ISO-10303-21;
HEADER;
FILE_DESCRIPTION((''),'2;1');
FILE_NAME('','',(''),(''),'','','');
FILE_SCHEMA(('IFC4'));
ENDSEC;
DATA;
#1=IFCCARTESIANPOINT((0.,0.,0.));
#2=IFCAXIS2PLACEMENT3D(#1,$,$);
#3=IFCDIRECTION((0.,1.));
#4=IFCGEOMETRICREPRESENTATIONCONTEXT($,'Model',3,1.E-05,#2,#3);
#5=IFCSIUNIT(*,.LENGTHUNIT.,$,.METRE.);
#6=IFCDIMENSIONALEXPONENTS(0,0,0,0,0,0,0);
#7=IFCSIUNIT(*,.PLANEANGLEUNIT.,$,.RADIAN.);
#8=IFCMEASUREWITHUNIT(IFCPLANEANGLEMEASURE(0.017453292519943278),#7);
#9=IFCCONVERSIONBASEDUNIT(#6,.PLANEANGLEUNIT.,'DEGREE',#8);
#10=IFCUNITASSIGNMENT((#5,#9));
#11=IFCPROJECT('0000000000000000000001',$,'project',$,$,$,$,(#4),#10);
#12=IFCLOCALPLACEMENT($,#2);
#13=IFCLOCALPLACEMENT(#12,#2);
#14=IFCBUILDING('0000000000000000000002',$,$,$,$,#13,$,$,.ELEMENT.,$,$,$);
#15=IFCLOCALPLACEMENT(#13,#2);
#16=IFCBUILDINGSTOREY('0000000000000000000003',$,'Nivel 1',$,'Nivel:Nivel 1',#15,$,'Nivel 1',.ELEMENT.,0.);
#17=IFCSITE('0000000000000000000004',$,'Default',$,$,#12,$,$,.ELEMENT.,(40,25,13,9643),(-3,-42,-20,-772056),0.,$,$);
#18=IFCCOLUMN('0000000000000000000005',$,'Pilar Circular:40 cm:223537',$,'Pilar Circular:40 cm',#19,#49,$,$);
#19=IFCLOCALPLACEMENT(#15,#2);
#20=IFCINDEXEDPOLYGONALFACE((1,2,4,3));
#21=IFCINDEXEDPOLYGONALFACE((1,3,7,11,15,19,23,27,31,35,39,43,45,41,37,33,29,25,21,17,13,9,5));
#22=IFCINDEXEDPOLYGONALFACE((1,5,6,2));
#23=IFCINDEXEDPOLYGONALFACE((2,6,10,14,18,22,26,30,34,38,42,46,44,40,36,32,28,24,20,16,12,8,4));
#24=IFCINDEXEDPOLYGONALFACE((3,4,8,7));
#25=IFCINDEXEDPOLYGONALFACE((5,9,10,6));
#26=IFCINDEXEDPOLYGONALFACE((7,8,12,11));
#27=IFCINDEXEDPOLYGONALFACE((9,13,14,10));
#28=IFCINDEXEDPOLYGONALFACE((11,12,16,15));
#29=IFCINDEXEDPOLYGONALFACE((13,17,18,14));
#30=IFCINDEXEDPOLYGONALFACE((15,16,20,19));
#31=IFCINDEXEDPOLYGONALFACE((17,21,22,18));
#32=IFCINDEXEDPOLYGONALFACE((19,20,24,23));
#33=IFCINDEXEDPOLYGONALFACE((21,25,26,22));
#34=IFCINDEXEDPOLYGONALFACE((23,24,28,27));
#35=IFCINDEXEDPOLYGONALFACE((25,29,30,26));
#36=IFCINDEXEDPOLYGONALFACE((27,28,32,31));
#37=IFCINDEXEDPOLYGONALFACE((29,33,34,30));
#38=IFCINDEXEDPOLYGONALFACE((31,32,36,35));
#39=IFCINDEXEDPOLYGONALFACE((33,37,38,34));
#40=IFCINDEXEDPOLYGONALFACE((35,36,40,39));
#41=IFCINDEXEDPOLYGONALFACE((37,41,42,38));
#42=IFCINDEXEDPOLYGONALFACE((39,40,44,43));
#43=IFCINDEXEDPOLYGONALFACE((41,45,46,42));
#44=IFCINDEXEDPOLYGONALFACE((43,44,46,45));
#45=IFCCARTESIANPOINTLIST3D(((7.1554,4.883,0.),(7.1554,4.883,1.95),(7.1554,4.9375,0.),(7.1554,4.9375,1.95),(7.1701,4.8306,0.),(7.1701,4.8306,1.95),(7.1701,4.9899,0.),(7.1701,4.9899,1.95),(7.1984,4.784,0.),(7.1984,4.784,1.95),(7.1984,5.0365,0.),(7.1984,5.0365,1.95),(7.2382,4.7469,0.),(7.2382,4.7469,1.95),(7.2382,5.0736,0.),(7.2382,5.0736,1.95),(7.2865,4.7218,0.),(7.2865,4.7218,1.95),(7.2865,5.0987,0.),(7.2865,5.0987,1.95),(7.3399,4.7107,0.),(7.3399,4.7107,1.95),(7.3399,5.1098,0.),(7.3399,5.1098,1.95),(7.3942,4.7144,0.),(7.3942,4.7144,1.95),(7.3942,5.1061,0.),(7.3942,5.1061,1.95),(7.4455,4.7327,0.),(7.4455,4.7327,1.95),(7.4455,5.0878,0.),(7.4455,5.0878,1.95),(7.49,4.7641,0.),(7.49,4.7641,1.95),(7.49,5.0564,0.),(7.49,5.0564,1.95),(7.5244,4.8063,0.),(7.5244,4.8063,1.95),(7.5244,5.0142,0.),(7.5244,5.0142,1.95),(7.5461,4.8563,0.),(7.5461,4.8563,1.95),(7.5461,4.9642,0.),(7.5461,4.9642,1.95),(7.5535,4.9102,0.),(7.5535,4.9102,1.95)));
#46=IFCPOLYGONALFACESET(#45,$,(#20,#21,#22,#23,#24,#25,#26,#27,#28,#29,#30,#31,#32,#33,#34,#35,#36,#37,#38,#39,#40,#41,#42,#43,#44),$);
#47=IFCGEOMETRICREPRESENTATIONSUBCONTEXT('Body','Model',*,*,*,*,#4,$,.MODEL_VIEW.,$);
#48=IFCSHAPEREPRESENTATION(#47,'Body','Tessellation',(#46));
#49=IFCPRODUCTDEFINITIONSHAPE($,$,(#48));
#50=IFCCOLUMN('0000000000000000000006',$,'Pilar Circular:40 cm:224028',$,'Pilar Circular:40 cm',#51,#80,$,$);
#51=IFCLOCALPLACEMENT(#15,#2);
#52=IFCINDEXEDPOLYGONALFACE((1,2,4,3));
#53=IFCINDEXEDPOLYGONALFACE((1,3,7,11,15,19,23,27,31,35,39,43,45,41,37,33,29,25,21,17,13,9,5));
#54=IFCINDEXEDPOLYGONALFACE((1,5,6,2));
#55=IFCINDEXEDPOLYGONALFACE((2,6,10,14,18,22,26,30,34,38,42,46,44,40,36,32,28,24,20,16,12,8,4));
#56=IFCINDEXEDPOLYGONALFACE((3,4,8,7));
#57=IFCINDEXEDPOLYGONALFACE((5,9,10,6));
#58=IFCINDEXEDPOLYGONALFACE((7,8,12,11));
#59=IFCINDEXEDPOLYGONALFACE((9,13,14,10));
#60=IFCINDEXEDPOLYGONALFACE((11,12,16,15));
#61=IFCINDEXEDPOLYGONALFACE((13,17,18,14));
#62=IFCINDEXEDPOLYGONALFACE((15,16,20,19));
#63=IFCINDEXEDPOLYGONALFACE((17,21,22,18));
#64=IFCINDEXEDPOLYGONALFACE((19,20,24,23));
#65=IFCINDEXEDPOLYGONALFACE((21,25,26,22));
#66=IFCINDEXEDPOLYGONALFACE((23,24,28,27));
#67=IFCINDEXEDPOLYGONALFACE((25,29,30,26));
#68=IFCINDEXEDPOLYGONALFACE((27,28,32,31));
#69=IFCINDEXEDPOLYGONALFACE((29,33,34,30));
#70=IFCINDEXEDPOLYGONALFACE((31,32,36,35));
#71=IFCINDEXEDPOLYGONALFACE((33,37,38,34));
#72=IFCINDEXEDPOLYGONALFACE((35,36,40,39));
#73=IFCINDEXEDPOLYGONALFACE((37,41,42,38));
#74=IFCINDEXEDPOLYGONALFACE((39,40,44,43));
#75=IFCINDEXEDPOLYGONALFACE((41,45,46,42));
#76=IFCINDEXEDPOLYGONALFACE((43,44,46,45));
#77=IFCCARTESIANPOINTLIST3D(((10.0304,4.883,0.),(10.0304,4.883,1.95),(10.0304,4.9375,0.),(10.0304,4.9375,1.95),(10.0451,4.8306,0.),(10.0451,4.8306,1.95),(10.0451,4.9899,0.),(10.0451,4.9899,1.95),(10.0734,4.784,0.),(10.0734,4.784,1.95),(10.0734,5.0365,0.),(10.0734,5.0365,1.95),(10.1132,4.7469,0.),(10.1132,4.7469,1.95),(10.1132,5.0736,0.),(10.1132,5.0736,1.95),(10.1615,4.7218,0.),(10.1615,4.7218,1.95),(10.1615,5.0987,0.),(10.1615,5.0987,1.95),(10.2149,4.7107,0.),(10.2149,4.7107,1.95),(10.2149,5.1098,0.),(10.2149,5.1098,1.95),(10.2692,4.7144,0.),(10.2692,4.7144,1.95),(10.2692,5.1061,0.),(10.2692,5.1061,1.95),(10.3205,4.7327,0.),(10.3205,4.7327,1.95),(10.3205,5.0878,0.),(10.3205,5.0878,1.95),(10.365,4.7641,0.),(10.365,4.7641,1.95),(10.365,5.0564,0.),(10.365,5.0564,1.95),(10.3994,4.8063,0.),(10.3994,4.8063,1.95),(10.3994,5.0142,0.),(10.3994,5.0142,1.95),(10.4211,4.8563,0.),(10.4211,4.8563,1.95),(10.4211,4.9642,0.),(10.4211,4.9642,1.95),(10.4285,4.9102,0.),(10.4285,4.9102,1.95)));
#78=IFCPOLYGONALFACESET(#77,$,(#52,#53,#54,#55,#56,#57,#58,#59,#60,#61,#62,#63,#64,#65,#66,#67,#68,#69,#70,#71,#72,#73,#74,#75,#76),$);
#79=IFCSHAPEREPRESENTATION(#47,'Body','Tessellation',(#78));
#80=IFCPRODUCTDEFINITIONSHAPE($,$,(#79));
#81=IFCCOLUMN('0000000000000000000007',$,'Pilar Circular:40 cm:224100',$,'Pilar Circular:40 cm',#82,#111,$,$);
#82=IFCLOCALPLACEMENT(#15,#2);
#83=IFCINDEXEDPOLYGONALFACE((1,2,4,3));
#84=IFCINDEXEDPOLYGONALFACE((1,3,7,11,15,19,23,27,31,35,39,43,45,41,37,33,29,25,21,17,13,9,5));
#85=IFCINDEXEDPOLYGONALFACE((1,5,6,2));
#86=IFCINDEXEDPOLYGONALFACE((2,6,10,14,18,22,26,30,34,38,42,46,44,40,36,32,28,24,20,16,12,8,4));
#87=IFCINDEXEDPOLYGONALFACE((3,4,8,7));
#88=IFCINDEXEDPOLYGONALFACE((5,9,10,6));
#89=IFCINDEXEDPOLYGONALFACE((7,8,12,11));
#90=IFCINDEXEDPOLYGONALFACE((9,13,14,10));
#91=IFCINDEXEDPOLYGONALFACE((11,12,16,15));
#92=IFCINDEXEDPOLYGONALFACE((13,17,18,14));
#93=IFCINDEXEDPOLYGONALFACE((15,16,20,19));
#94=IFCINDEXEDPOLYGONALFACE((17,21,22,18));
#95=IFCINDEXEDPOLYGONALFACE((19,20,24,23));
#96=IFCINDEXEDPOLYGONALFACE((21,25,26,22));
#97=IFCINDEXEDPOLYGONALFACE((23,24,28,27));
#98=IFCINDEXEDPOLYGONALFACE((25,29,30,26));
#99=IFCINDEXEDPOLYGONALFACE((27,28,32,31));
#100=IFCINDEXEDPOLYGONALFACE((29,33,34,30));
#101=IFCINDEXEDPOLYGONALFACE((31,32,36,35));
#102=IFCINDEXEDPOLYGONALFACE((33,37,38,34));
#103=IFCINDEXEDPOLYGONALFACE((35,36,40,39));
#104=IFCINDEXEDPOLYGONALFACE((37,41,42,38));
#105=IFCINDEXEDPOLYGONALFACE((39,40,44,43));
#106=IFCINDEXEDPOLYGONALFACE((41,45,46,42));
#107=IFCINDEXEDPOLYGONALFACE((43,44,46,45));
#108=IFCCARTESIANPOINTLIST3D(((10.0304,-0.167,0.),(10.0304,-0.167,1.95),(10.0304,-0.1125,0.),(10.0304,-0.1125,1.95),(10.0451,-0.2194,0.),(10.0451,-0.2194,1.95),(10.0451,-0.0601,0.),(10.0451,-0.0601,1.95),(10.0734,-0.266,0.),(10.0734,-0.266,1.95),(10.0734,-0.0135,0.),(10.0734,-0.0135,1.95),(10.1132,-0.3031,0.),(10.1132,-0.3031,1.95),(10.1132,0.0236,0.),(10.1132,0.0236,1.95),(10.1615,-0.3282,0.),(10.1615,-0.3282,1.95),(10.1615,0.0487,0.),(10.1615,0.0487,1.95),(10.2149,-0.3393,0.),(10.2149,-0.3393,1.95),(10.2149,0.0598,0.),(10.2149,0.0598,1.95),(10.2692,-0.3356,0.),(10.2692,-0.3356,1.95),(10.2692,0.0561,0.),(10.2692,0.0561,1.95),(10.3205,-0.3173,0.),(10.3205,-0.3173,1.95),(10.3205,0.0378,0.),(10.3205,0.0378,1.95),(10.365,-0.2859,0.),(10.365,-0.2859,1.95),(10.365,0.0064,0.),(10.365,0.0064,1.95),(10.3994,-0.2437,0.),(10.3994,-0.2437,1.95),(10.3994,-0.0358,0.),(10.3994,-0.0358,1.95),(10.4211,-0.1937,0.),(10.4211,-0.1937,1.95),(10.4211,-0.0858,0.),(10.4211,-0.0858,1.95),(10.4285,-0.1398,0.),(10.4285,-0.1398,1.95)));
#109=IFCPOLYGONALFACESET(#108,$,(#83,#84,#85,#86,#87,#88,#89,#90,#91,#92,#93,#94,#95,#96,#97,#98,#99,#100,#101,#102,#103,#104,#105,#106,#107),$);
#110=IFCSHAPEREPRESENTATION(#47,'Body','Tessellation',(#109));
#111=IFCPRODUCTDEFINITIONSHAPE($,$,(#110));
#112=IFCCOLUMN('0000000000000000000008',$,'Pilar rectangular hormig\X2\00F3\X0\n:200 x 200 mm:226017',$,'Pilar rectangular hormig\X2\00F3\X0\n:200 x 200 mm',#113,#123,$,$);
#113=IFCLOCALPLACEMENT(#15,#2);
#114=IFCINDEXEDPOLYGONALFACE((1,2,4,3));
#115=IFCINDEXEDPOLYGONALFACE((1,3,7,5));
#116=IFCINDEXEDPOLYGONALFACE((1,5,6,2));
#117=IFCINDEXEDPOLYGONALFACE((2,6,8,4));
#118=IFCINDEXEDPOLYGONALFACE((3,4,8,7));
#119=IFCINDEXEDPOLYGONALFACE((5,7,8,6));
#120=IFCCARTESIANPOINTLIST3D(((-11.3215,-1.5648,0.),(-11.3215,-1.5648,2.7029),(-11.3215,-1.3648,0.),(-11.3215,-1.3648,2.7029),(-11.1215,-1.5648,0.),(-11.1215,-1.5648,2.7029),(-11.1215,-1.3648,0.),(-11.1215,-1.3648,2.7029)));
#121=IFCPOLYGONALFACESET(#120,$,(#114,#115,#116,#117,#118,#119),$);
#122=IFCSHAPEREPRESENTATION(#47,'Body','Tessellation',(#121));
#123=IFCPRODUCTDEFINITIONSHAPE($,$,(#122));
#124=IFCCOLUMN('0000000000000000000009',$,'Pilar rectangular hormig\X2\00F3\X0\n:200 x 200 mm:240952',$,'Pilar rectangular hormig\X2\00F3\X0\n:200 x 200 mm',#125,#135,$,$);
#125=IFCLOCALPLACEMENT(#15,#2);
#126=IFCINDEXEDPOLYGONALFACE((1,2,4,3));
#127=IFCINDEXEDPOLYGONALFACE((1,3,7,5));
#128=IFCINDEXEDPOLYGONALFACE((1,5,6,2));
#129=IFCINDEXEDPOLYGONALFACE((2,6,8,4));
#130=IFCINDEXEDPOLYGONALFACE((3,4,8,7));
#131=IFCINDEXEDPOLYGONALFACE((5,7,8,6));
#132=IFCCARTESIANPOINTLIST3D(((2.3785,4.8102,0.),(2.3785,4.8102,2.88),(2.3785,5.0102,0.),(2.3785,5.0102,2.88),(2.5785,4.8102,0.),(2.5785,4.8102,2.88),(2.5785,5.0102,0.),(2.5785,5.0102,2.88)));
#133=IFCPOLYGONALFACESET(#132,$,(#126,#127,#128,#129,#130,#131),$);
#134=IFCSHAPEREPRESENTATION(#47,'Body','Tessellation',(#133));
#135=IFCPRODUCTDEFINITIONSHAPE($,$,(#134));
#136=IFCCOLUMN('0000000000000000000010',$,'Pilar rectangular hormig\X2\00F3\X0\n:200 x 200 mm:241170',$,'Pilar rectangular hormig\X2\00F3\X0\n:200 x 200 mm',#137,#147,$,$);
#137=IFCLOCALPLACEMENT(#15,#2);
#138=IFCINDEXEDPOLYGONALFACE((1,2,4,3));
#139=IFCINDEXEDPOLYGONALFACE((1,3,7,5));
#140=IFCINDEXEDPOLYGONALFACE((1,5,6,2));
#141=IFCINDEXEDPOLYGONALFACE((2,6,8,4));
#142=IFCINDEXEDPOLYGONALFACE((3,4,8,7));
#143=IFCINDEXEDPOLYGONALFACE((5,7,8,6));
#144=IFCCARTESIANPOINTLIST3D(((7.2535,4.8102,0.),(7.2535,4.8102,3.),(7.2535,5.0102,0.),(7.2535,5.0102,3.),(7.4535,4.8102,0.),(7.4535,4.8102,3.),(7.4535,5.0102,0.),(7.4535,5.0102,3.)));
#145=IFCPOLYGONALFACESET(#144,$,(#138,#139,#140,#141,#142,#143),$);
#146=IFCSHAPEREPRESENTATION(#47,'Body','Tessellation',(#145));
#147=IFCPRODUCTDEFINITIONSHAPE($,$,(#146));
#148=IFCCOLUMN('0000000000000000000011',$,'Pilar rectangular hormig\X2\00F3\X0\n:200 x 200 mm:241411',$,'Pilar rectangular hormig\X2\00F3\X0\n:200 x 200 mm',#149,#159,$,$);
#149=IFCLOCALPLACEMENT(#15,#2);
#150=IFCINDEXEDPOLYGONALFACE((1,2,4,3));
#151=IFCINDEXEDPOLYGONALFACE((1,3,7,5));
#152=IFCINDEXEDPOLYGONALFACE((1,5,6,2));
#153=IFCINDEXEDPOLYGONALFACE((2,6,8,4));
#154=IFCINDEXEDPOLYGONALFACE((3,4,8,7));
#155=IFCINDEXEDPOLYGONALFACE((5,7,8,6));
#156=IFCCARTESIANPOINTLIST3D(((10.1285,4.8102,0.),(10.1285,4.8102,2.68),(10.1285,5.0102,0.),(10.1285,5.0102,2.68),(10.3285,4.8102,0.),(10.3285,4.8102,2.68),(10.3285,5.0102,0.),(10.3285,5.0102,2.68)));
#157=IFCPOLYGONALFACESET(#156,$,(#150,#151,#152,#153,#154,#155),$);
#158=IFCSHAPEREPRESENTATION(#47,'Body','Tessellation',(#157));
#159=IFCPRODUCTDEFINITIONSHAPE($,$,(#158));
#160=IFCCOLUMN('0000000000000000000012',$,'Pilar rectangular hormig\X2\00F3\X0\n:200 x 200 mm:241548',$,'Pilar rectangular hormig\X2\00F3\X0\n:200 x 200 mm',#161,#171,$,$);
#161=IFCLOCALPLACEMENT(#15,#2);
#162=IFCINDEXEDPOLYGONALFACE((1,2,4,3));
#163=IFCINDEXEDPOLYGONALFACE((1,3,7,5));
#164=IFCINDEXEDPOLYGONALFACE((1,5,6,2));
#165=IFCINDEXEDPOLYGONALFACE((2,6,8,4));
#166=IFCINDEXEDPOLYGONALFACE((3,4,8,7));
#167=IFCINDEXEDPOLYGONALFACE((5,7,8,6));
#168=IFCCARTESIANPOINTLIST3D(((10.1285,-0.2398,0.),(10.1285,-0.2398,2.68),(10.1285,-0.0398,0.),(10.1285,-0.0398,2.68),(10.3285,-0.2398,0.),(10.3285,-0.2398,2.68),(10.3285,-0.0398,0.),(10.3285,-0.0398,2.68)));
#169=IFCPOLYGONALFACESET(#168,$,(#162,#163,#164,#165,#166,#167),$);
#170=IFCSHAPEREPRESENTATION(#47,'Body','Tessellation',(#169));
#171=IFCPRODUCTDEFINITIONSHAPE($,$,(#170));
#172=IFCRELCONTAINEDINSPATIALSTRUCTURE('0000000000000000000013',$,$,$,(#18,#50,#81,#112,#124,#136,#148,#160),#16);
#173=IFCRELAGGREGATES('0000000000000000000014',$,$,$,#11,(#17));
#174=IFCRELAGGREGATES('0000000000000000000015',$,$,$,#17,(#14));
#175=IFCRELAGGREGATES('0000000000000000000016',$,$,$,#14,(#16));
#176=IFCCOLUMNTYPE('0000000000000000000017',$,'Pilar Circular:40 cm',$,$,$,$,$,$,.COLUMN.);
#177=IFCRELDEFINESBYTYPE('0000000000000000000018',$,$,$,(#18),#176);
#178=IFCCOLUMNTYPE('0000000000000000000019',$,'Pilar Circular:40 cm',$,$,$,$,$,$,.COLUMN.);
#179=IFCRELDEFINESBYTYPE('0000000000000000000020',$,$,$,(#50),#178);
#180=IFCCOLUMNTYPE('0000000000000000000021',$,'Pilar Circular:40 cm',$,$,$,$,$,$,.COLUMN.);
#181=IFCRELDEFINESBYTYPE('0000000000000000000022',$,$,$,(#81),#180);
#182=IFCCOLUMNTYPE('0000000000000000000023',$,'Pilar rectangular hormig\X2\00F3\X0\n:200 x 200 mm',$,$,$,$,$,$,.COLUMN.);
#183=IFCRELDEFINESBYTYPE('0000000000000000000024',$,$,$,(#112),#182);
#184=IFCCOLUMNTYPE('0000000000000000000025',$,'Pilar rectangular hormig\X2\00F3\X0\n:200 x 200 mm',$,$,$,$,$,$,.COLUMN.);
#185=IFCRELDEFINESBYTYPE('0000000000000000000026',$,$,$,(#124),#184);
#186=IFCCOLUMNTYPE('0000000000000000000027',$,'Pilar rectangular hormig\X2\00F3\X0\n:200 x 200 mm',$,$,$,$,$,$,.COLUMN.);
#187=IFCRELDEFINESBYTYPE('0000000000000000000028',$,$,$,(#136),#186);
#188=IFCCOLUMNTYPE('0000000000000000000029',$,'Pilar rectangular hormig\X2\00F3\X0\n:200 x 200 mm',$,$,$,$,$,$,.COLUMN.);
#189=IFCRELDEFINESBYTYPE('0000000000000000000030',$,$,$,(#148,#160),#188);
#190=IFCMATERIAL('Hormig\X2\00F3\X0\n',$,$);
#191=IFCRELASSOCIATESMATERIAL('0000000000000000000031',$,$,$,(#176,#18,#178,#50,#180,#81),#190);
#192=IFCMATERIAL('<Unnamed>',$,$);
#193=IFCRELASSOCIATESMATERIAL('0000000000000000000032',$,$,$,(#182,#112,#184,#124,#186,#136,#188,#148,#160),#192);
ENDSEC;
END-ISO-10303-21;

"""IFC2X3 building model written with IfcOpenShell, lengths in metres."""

from ifc_helpers import new_model, entity, si_unit, converted_unit, direction, frame, frame_2d, origin, origin_2d_with_axis, place, context, subcontext, project, spatial, rectangle, circle, extrude, source, transform, mapped, material, type_object, type_shapes, element, save


model = new_model("IFC2X3")

# Units and contexts
model_context = context("Model", 3, precision=1e-05, world=origin(), true_north=direction((0.0, 1.0)))
body_context = subcontext(model_context, "Body", "Model", "MODEL_VIEW")
ifc_project = project(units=[si_unit("LENGTHUNIT", "METRE"), converted_unit("PLANEANGLEUNIT", "DEGREE", entity("IfcPlaneAngleMeasure", 0.017453292519943278), si_unit("PLANEANGLEUNIT", "RADIAN"), dimensions=[0, 0, 0, 0, 0, 0, 0])], contexts=[model_context])

# Site, building, storey
site_placement = place(None, origin())
site = spatial("IfcSite", under=ifc_project, at=site_placement, Name="Default", CompositionType="ELEMENT", RefLatitude=(40, 25, 13, 9643), RefLongitude=(-3, -42, -20, -772056), RefElevation=0.0)
building_placement = place(site_placement, origin())
building = spatial("IfcBuilding", under=site, at=building_placement, CompositionType="ELEMENT")
storey_placement = place(building_placement, origin())
storey = spatial("IfcBuildingStorey", under=building, at=storey_placement, Name="Nivel 1", ObjectType="Nivel:Nivel 1", LongName="Nivel 1", CompositionType="ELEMENT", Elevation=0.0)

# Columns
ifc_material_1 = material(Name="Hormigón")
column_type_1 = type_object("IfcColumnType", Name="Pilar Circular:40 cm", PredefinedType="COLUMN", material=ifc_material_1)
shared_shape_1 = source(origin(), body_context, "Body", "SweptSolid", [
    extrude(circle(Radius=0.2, at=origin_2d_with_axis()), frame((7.3535, 4.9102, 0.0)), (0.0, 0.0, 1.0), 1.95),
])
type_shapes(column_type_1, [shared_shape_1])
column_1_placement = place(storey_placement, origin())
element("IfcColumn", 1, at=column_1_placement, inside=storey, type_object=column_type_1, material=ifc_material_1, Name="Pilar Circular:40 cm:223537", ObjectType="Pilar Circular:40 cm", context=body_context, shape_type="MappedRepresentation", body=[
    mapped(shared_shape_1, transform((0.0, 0.0, 0.0), scale=1.0)),
])
column_type_2 = type_object("IfcColumnType", Name="Pilar Circular:40 cm", PredefinedType="COLUMN", material=ifc_material_1)
shared_shape_2 = source(origin(), body_context, "Body", "SweptSolid", [
    extrude(circle(Radius=0.2, at=frame_2d((0.0, 0.0), x_axis=(1.0, 0.0))), frame((10.2285, 4.9102, 0.0)), (0.0, 0.0, 1.0), 1.95),
])
type_shapes(column_type_2, [shared_shape_2])
column_2_placement = place(storey_placement, origin())
element("IfcColumn", 2, at=column_2_placement, inside=storey, type_object=column_type_2, material=ifc_material_1, Name="Pilar Circular:40 cm:224028", ObjectType="Pilar Circular:40 cm", context=body_context, shape_type="MappedRepresentation", body=[
    mapped(shared_shape_2, transform((0.0, 0.0, 0.0), scale=1.0)),
])
column_type_3 = type_object("IfcColumnType", Name="Pilar Circular:40 cm", PredefinedType="COLUMN", material=ifc_material_1)
shared_shape_3 = source(origin(), body_context, "Body", "SweptSolid", [
    extrude(circle(Radius=0.2, at=frame_2d((0.0, 0.0), x_axis=(1.0, 0.0))), frame((10.2285, -0.1398, 0.0)), (0.0, 0.0, 1.0), 1.95),
])
type_shapes(column_type_3, [shared_shape_3])
column_3_placement = place(storey_placement, origin())
element("IfcColumn", 3, at=column_3_placement, inside=storey, type_object=column_type_3, material=ifc_material_1, Name="Pilar Circular:40 cm:224100", ObjectType="Pilar Circular:40 cm", context=body_context, shape_type="MappedRepresentation", body=[
    mapped(shared_shape_3, transform((0.0, 0.0, 0.0), scale=1.0)),
])
ifc_material_2 = material(Name="<Unnamed>")
column_type_4 = type_object("IfcColumnType", Name="Pilar rectangular hormigón:200 x 200 mm", PredefinedType="COLUMN", material=ifc_material_2)
shared_shape_4 = source(origin(), body_context, "Body", "SweptSolid", [
    extrude(rectangle(XDim=0.2, YDim=0.2, at=frame_2d((0.0, 0.0), x_axis=(1.0, 0.0))), frame((-11.2215, -1.4648, 0.0), z_axis=(0.0, 0.0, 1.0), x_axis=(-1.0, 0.0, 0.0)), (0.0, 0.0, 1.0), 2.7029),
])
type_shapes(column_type_4, [shared_shape_4])
column_4_placement = place(storey_placement, origin())
element("IfcColumn", 4, at=column_4_placement, inside=storey, type_object=column_type_4, material=ifc_material_2, Name="Pilar rectangular hormigón:200 x 200 mm:226017", ObjectType="Pilar rectangular hormigón:200 x 200 mm", context=body_context, shape_type="MappedRepresentation", body=[
    mapped(shared_shape_4, transform((0.0, 0.0, 0.0), scale=1.0)),
])
column_type_5 = type_object("IfcColumnType", Name="Pilar rectangular hormigón:200 x 200 mm", PredefinedType="COLUMN", material=ifc_material_2)
shared_shape_5 = source(origin(), body_context, "Body", "SweptSolid", [
    extrude(rectangle(XDim=0.2, YDim=0.2, at=origin_2d_with_axis()), frame((2.4785, 4.9102, 0.0), z_axis=(0.0, 0.0, 1.0), x_axis=(-1.0, 0.0, 0.0)), (0.0, 0.0, 1.0), 2.88),
])
type_shapes(column_type_5, [shared_shape_5])
column_5_placement = place(storey_placement, origin())
element("IfcColumn", 5, at=column_5_placement, inside=storey, type_object=column_type_5, material=ifc_material_2, Name="Pilar rectangular hormigón:200 x 200 mm:240952", ObjectType="Pilar rectangular hormigón:200 x 200 mm", context=body_context, shape_type="MappedRepresentation", body=[
    mapped(shared_shape_5, transform((0.0, 0.0, 0.0), scale=1.0)),
])
column_type_6 = type_object("IfcColumnType", Name="Pilar rectangular hormigón:200 x 200 mm", PredefinedType="COLUMN", material=ifc_material_2)
shared_shape_6 = source(origin(), body_context, "Body", "SweptSolid", [
    extrude(rectangle(XDim=0.2, YDim=0.2, at=origin_2d_with_axis()), frame((0.0, 0.0, 0.0), z_axis=(0.0, 0.0, 1.0), x_axis=(-1.0, 0.0, 0.0)), (0.0, 0.0, 1.0), 3.0),
])
type_shapes(column_type_6, [shared_shape_6])
column_6_placement = place(storey_placement, frame((7.3535, 4.9102, 0.0)))
element("IfcColumn", 6, at=column_6_placement, inside=storey, type_object=column_type_6, material=ifc_material_2, Name="Pilar rectangular hormigón:200 x 200 mm:241170", ObjectType="Pilar rectangular hormigón:200 x 200 mm", context=body_context, shape_type="MappedRepresentation", body=[
    mapped(shared_shape_6, transform((0.0, 0.0, 0.0), scale=1.0)),
])
column_type_7 = type_object("IfcColumnType", Name="Pilar rectangular hormigón:200 x 200 mm", PredefinedType="COLUMN", material=ifc_material_2)
shared_shape_7 = source(origin(), body_context, "Body", "SweptSolid", [
    extrude(rectangle(XDim=0.2, YDim=0.2, at=origin_2d_with_axis()), frame((0.0, 0.0, 0.0), z_axis=(0.0, 0.0, 1.0), x_axis=(-1.0, 0.0, 0.0)), (0.0, 0.0, 1.0), 2.68),
])
type_shapes(column_type_7, [shared_shape_7])
for number, where, name in (
    (7, (10.2285, 4.9102, 0.0), "Pilar rectangular hormigón:200 x 200 mm:241411"),
    (8, (10.2285, -0.1398, 0.0), "Pilar rectangular hormigón:200 x 200 mm:241548"),
):
    element("IfcColumn", number, at=place(storey_placement, frame(where)), inside=storey, type_object=column_type_7, material=ifc_material_2, Name=name, ObjectType="Pilar rectangular hormigón:200 x 200 mm", context=body_context, shape_type="MappedRepresentation", body=[
        mapped(shared_shape_7, transform((0.0, 0.0, 0.0), scale=1.0)),
    ])

save(model, "model.ifc")
